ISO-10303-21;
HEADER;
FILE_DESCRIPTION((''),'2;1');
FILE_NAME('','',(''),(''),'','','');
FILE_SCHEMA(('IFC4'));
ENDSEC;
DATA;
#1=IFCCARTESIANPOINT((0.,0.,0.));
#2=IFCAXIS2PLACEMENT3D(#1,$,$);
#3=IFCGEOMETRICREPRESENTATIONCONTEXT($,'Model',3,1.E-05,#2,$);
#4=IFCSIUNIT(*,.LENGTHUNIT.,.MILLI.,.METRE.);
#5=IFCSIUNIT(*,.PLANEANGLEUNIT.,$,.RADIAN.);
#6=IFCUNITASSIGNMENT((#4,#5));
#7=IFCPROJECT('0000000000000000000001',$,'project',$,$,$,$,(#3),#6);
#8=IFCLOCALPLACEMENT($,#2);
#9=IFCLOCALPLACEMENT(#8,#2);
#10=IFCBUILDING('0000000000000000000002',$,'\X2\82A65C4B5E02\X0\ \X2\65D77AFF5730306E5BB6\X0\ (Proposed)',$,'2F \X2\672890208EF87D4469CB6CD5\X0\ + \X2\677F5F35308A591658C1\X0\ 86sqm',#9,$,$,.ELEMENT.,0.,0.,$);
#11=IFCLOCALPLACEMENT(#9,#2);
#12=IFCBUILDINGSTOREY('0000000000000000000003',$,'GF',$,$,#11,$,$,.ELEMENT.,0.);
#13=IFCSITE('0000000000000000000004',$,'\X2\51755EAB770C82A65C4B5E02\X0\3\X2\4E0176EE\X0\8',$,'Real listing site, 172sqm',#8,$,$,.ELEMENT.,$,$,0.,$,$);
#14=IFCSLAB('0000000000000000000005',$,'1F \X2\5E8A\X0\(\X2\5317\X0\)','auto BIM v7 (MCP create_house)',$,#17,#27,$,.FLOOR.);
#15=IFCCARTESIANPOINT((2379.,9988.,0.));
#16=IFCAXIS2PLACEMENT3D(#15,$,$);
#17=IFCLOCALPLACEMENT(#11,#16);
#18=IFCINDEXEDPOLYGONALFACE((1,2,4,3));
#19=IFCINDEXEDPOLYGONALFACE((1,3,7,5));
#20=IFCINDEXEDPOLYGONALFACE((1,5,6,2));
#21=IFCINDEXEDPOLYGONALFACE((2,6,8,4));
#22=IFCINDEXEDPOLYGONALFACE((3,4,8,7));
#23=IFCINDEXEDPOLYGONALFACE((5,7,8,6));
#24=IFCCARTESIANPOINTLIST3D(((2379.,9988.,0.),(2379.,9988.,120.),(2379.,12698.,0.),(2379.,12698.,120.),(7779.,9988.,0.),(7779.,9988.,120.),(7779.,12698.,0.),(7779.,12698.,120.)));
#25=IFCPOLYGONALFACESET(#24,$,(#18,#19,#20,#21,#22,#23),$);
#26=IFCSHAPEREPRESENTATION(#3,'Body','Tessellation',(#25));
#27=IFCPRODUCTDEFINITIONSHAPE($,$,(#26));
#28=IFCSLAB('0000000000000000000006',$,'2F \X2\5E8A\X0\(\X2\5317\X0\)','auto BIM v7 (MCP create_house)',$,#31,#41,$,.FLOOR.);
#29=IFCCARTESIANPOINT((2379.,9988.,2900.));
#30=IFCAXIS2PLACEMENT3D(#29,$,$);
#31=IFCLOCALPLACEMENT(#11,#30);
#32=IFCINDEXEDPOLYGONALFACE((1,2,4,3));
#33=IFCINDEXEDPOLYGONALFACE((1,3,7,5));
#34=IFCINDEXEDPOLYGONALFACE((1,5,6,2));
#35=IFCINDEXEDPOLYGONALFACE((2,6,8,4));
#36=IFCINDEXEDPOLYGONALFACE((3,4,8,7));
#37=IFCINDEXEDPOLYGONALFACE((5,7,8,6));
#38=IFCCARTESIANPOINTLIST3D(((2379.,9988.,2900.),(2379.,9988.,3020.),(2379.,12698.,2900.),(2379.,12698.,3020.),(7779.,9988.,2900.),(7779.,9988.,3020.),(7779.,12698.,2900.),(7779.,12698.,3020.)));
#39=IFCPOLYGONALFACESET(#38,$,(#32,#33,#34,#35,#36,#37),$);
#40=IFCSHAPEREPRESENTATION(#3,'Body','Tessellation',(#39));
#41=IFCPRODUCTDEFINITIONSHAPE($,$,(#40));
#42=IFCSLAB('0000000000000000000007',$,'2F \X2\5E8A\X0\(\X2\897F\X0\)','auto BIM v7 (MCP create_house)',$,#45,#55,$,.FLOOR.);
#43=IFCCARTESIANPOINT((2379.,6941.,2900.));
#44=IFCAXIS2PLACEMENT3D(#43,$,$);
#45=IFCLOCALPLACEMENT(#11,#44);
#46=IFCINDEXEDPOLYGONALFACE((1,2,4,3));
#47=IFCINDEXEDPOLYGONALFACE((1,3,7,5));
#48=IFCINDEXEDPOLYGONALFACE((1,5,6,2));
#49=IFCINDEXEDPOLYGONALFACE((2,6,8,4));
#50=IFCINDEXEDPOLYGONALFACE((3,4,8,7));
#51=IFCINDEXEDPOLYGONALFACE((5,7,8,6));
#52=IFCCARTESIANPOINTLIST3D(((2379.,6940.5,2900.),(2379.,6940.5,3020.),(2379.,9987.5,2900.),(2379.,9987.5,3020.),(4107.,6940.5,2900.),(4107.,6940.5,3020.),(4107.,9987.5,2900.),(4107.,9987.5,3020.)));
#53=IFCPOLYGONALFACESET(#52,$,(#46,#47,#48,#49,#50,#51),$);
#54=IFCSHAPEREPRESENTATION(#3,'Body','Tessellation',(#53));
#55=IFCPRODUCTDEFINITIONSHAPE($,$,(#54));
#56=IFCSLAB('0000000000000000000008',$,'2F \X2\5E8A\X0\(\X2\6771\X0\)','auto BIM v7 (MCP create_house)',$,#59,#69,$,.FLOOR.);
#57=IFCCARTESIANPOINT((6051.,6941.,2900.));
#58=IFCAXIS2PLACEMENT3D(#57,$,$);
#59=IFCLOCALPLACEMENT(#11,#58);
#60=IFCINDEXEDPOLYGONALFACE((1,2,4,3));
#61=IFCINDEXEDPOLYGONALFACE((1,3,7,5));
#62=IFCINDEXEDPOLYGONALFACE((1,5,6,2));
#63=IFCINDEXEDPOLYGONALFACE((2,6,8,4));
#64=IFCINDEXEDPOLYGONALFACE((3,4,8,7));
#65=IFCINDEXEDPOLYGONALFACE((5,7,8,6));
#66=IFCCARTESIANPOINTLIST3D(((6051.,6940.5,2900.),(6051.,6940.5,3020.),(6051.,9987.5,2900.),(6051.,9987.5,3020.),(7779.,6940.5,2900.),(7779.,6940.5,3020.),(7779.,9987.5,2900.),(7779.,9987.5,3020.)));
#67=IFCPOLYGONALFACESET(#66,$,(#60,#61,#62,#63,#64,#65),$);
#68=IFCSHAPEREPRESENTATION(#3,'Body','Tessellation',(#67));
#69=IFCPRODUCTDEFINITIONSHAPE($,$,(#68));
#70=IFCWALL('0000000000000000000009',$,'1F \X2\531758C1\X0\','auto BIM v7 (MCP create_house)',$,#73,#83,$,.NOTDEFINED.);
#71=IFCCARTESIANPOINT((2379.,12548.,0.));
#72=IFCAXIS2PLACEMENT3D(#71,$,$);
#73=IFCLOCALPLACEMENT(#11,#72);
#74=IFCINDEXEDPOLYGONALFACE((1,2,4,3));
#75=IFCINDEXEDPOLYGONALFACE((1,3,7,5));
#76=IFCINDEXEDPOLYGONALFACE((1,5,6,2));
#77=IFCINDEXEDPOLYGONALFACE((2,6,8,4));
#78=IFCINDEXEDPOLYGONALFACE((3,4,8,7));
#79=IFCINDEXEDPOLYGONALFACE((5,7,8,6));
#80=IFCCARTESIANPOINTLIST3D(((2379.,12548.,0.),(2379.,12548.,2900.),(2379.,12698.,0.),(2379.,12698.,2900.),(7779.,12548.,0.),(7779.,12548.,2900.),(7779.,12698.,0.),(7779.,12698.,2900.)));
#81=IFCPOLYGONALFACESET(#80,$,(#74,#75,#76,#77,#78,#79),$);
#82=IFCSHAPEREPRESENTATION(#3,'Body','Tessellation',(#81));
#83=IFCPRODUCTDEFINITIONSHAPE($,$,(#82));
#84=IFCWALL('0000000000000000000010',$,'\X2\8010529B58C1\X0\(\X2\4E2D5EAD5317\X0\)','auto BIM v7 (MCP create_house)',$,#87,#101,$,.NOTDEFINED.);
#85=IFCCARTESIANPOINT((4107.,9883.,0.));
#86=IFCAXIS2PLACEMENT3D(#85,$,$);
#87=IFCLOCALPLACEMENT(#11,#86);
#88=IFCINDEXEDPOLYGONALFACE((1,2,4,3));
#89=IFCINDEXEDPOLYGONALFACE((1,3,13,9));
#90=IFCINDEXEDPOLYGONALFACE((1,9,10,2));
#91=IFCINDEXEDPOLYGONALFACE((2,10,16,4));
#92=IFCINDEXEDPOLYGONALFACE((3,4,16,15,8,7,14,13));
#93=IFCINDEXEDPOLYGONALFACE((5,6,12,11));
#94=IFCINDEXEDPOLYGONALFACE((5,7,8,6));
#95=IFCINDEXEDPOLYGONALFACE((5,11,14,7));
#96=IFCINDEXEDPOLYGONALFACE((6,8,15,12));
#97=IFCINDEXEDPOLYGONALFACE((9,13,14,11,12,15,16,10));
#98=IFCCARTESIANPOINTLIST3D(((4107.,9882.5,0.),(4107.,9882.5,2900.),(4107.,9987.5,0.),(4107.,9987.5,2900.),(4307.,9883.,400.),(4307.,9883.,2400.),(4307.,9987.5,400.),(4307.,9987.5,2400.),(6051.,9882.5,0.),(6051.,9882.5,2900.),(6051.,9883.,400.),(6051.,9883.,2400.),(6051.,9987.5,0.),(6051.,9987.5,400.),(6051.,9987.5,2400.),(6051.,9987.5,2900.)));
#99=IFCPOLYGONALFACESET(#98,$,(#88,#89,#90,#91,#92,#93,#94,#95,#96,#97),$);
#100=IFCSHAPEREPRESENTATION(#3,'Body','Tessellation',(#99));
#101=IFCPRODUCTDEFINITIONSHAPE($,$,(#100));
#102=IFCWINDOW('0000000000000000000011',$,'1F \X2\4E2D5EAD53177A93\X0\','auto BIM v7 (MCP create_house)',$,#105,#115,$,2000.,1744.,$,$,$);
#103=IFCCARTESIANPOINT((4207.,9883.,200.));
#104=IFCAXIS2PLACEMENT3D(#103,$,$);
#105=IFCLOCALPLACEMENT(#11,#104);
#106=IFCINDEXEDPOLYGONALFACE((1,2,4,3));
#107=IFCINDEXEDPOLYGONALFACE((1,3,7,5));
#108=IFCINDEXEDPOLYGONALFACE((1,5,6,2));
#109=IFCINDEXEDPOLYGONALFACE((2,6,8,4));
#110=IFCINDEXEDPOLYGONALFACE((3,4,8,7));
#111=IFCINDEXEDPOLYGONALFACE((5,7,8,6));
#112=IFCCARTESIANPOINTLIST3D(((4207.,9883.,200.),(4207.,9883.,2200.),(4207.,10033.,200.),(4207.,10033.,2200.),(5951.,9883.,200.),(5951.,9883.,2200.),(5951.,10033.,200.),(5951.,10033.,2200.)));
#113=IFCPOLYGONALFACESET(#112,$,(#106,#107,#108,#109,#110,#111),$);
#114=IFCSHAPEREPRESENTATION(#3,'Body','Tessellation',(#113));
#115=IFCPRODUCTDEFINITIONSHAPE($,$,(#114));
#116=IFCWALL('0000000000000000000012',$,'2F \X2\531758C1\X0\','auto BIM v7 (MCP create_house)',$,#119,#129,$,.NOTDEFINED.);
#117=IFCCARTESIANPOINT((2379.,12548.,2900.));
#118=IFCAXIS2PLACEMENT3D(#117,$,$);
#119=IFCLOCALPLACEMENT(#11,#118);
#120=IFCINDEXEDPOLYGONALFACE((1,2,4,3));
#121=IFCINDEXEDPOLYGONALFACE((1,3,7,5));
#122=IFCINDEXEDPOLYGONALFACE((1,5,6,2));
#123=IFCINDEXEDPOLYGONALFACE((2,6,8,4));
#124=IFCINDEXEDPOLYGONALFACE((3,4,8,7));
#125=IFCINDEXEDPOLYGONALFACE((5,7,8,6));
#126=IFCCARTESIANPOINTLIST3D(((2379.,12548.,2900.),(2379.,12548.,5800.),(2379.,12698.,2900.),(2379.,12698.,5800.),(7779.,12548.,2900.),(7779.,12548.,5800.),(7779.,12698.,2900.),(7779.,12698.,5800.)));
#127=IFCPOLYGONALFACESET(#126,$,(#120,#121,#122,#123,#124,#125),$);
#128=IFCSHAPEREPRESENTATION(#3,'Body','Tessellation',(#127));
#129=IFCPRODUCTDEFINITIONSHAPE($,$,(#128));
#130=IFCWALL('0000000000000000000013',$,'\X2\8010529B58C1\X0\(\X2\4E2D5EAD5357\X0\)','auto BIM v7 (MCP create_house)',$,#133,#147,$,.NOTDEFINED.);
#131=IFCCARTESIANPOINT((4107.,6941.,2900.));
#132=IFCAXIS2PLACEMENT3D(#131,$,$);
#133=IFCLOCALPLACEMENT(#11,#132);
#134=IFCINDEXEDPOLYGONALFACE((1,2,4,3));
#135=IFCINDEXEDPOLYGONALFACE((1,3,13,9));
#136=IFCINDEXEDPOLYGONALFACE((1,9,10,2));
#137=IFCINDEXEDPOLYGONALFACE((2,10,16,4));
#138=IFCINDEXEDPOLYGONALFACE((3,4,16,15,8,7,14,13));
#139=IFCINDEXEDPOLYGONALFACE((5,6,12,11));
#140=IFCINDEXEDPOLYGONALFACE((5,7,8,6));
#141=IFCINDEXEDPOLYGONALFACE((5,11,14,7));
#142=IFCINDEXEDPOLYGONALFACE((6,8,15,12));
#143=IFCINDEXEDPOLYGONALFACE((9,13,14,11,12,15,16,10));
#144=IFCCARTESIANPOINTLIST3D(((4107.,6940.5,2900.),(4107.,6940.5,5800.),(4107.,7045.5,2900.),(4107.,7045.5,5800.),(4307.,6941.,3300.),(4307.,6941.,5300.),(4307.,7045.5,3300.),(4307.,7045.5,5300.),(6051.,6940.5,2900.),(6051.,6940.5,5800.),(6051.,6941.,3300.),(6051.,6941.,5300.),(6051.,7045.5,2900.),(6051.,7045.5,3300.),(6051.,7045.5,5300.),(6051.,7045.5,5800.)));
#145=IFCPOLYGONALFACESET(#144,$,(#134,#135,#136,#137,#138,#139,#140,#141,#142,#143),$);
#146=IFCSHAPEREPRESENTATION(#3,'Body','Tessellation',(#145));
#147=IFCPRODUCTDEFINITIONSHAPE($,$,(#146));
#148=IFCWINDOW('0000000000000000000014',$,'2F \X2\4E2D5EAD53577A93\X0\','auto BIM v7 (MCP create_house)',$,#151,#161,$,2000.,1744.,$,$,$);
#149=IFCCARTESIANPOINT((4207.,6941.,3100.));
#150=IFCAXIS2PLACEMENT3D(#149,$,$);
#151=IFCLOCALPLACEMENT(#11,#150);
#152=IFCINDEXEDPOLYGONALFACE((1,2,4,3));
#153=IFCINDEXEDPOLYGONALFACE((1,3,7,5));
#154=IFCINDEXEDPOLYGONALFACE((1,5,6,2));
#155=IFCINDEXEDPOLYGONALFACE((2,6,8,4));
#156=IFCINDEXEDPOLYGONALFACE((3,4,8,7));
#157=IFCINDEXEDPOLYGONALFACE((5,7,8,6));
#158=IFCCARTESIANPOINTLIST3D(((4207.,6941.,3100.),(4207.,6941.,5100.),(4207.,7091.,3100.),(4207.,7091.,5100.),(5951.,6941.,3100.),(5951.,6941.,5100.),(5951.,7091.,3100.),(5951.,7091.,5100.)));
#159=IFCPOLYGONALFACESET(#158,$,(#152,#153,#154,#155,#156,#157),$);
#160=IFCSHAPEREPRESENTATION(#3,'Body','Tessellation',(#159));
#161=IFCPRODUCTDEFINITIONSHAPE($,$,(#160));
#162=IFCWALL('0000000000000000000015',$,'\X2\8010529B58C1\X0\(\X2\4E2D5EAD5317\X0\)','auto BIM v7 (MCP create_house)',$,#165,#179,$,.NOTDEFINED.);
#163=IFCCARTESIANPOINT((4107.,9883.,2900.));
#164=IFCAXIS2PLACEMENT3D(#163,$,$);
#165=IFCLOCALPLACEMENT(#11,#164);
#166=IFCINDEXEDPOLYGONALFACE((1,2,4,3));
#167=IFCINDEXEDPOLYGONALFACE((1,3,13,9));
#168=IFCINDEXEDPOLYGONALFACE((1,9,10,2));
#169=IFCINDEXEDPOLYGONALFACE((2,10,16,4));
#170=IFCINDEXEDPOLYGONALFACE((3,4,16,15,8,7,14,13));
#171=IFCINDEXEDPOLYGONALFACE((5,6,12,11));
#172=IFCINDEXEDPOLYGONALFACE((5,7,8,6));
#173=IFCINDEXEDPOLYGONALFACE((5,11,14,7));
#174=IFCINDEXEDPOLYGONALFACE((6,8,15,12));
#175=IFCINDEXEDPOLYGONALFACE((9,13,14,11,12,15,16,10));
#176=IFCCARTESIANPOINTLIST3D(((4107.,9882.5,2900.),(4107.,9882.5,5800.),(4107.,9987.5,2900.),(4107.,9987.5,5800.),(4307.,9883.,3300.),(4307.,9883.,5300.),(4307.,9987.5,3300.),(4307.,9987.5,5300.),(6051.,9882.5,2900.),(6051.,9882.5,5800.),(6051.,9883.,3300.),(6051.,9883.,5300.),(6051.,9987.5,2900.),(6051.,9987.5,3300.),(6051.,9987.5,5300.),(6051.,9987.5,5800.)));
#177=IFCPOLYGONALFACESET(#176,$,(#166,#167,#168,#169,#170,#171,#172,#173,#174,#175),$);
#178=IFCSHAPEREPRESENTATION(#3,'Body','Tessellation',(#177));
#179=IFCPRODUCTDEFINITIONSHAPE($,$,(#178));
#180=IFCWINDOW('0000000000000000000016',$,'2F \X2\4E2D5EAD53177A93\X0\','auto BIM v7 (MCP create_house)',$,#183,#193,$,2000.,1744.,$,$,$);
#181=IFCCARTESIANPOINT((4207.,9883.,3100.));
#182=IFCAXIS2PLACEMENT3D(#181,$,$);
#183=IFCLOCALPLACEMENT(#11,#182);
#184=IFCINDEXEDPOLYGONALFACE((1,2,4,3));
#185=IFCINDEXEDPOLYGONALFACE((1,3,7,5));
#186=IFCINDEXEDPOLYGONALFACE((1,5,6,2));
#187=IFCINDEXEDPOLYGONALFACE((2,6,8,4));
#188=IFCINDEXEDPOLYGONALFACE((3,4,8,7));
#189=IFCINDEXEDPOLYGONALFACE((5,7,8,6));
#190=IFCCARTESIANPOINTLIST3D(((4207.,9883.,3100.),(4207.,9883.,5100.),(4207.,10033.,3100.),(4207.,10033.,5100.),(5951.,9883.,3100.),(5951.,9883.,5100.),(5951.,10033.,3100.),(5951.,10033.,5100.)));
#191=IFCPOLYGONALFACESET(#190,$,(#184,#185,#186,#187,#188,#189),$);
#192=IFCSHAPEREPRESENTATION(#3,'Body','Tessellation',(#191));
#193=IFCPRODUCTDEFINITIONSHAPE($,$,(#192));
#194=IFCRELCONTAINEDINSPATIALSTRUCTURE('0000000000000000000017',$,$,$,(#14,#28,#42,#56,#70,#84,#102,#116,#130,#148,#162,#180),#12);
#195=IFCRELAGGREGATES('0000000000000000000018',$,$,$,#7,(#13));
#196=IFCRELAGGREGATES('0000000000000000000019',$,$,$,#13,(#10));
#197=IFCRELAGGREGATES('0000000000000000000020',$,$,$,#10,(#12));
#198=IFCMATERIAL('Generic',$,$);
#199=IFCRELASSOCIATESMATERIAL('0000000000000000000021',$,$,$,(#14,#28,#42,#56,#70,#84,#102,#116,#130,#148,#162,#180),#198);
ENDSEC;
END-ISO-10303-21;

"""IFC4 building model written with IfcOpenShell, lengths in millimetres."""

from ifc_helpers import new_model, si_unit, frame, frame_2d, origin, place, context, project, spatial, rectangle, extrude, material, element, fill, save


model = new_model("IFC4")

# Units and contexts
model_context = context("Model", 3, precision=1e-05, world=origin())
ifc_project = project(units=[si_unit("LENGTHUNIT", "METRE", prefix="MILLI"), si_unit("PLANEANGLEUNIT", "RADIAN")], contexts=[model_context])

# Site, building, storey
site_placement = place(None, origin())
site = spatial("IfcSite", under=ifc_project, at=site_placement, Name="兵庫県芦屋市3丁目8", ObjectType="Real listing site, 172sqm", CompositionType="ELEMENT", RefElevation=0.0)
building_placement = place(site_placement, origin())
building = spatial("IfcBuilding", under=site, at=building_placement, Name="芦屋市 旗竿地の家 (Proposed)", ObjectType="2F 木造軸組構法 + 板張り外壁 86sqm", CompositionType="ELEMENT", ElevationOfRefHeight=0.0, ElevationOfTerrain=0.0)
storey_placement = place(building_placement, origin())
storey = spatial("IfcBuildingStorey", under=building, at=storey_placement, Name="GF", CompositionType="ELEMENT", Elevation=0.0)

# Slabs
ifc_material = material(Name="Generic")
slab_1_placement = place(storey_placement, frame((2379.0, 9988.0, 0.0)))
element("IfcSlab", 1, at=slab_1_placement, inside=storey, material=ifc_material, Name="1F 床(北)", Description="auto BIM v7 (MCP create_house)", PredefinedType="FLOOR", context=model_context, shape_type="SweptSolid", body=[
    extrude(rectangle(XDim=5400.0, YDim=2710.0, at=frame_2d((2700.0, 1355.0))), frame((2379.0, 9988.0, 0.0)), (0.0, 0.0, 1.0), 120.0),
])
slab_2_placement = place(storey_placement, frame((2379.0, 9988.0, 2900.0)))
element("IfcSlab", 2, at=slab_2_placement, inside=storey, material=ifc_material, Name="2F 床(北)", Description="auto BIM v7 (MCP create_house)", PredefinedType="FLOOR", context=model_context, shape_type="SweptSolid", body=[
    extrude(rectangle(XDim=5400.0, YDim=2710.0, at=frame_2d((2700.0, 1355.0))), frame((2379.0, 9988.0, 2900.0)), (0.0, 0.0, 1.0), 120.0),
])
slab_3_placement = place(storey_placement, frame((2379.0, 6941.0, 2900.0)))
element("IfcSlab", 3, at=slab_3_placement, inside=storey, material=ifc_material, Name="2F 床(西)", Description="auto BIM v7 (MCP create_house)", PredefinedType="FLOOR", context=model_context, shape_type="SweptSolid", body=[
    extrude(rectangle(XDim=1728.0, YDim=3047.0, at=frame_2d((864.0, 1523.0))), frame((2379.0, 6941.0, 2900.0)), (0.0, 0.0, 1.0), 120.0),
])
slab_4_placement = place(storey_placement, frame((6051.0, 6941.0, 2900.0)))
element("IfcSlab", 4, at=slab_4_placement, inside=storey, material=ifc_material, Name="2F 床(東)", Description="auto BIM v7 (MCP create_house)", PredefinedType="FLOOR", context=model_context, shape_type="SweptSolid", body=[
    extrude(rectangle(XDim=1728.0, YDim=3047.0, at=frame_2d((864.0, 1523.0))), frame((6051.0, 6941.0, 2900.0)), (0.0, 0.0, 1.0), 120.0),
])

# Wall
wall_1_placement = place(storey_placement, frame((2379.0, 12548.0, 0.0)))
element("IfcWall", 5, at=wall_1_placement, inside=storey, material=ifc_material, Name="1F 北壁", Description="auto BIM v7 (MCP create_house)", PredefinedType="NOTDEFINED", context=model_context, shape_type="SweptSolid", body=[
    extrude(rectangle(XDim=5400.0, YDim=150.0, at=frame_2d((2700.0, 75.0))), frame((2379.0, 12548.0, 0.0)), (0.0, 0.0, 1.0), 2900.0),
])

# Wall, opening, window
wall_2_placement = place(storey_placement, frame((4107.0, 9883.0, 0.0)))
wall_2 = element("IfcWall", 6, at=wall_2_placement, inside=storey, material=ifc_material, Name="耐力壁(中庭北)", Description="auto BIM v7 (MCP create_house)", PredefinedType="NOTDEFINED", context=model_context, shape_type="SweptSolid", body=[
    extrude(rectangle(XDim=1944.0, YDim=105.0, at=frame_2d((972.0, 52.0))), frame((4107.0, 9883.0, 0.0)), (0.0, 0.0, 1.0), 2900.0),
])
opening_1_placement = place(storey_placement, frame((4207.0, 9883.0, 200.0)))
opening_1 = element("IfcOpeningElement", 7, at=opening_1_placement, cuts=wall_2, PredefinedType="NOTDEFINED", context=model_context, shape_type="SweptSolid", body=[
    extrude(rectangle(XDim=1744.0, YDim=150.0, at=frame_2d((872.0, 75.0))), frame((4207.0, 9883.0, 200.0)), (0.0, 0.0, 1.0), 2000.0),
])
window_1_placement = place(storey_placement, frame((4207.0, 9883.0, 200.0)))
window_1 = element("IfcWindow", 8, at=window_1_placement, inside=storey, material=ifc_material, Name="1F 中庭北窓", Description="auto BIM v7 (MCP create_house)", OverallHeight=2000.0, OverallWidth=1744.0, context=model_context, shape_type="SweptSolid", body=[
    extrude(rectangle(XDim=1744.0, YDim=150.0, at=frame_2d((872.0, 75.0))), frame((4207.0, 9883.0, 200.0)), (0.0, 0.0, 1.0), 2000.0),
])
fill(opening_1, window_1)

# Wall
wall_3_placement = place(storey_placement, frame((2379.0, 12548.0, 2900.0)))
element("IfcWall", 9, at=wall_3_placement, inside=storey, material=ifc_material, Name="2F 北壁", Description="auto BIM v7 (MCP create_house)", PredefinedType="NOTDEFINED", context=model_context, shape_type="SweptSolid", body=[
    extrude(rectangle(XDim=5400.0, YDim=150.0, at=frame_2d((2700.0, 75.0))), frame((2379.0, 12548.0, 2900.0)), (0.0, 0.0, 1.0), 2900.0),
])

# Walls, openings, windows
wall_4_placement = place(storey_placement, frame((4107.0, 6941.0, 2900.0)))
wall_4 = element("IfcWall", 10, at=wall_4_placement, inside=storey, material=ifc_material, Name="耐力壁(中庭南)", Description="auto BIM v7 (MCP create_house)", PredefinedType="NOTDEFINED", context=model_context, shape_type="SweptSolid", body=[
    extrude(rectangle(XDim=1944.0, YDim=105.0, at=frame_2d((972.0, 52.0))), frame((4107.0, 6941.0, 2900.0)), (0.0, 0.0, 1.0), 2900.0),
])
opening_2_placement = place(storey_placement, frame((4207.0, 6941.0, 3100.0)))
opening_2 = element("IfcOpeningElement", 11, at=opening_2_placement, cuts=wall_4, PredefinedType="NOTDEFINED", context=model_context, shape_type="SweptSolid", body=[
    extrude(rectangle(XDim=1744.0, YDim=150.0, at=frame_2d((872.0, 75.0))), frame((4207.0, 6941.0, 3100.0)), (0.0, 0.0, 1.0), 2000.0),
])
window_2_placement = place(storey_placement, frame((4207.0, 6941.0, 3100.0)))
window_2 = element("IfcWindow", 12, at=window_2_placement, inside=storey, material=ifc_material, Name="2F 中庭南窓", Description="auto BIM v7 (MCP create_house)", OverallHeight=2000.0, OverallWidth=1744.0, context=model_context, shape_type="SweptSolid", body=[
    extrude(rectangle(XDim=1744.0, YDim=150.0, at=frame_2d((872.0, 75.0))), frame((4207.0, 6941.0, 3100.0)), (0.0, 0.0, 1.0), 2000.0),
])
fill(opening_2, window_2)
wall_5_placement = place(storey_placement, frame((4107.0, 9883.0, 2900.0)))
wall_5 = element("IfcWall", 13, at=wall_5_placement, inside=storey, material=ifc_material, Name="耐力壁(中庭北)", Description="auto BIM v7 (MCP create_house)", PredefinedType="NOTDEFINED", context=model_context, shape_type="SweptSolid", body=[
    extrude(rectangle(XDim=1944.0, YDim=105.0, at=frame_2d((972.0, 52.0))), frame((4107.0, 9883.0, 2900.0)), (0.0, 0.0, 1.0), 2900.0),
])
opening_3_placement = place(storey_placement, frame((4207.0, 9883.0, 3100.0)))
opening_3 = element("IfcOpeningElement", 14, at=opening_3_placement, cuts=wall_5, PredefinedType="NOTDEFINED", context=model_context, shape_type="SweptSolid", body=[
    extrude(rectangle(XDim=1744.0, YDim=150.0, at=frame_2d((872.0, 75.0))), frame((4207.0, 9883.0, 3100.0)), (0.0, 0.0, 1.0), 2000.0),
])
window_3_placement = place(storey_placement, frame((4207.0, 9883.0, 3100.0)))
window_3 = element("IfcWindow", 15, at=window_3_placement, inside=storey, material=ifc_material, Name="2F 中庭北窓", Description="auto BIM v7 (MCP create_house)", OverallHeight=2000.0, OverallWidth=1744.0, context=model_context, shape_type="SweptSolid", body=[
    extrude(rectangle(XDim=1744.0, YDim=150.0, at=frame_2d((872.0, 75.0))), frame((4207.0, 9883.0, 3100.0)), (0.0, 0.0, 1.0), 2000.0),
])
fill(opening_3, window_3)

save(model, "model.ifc")
